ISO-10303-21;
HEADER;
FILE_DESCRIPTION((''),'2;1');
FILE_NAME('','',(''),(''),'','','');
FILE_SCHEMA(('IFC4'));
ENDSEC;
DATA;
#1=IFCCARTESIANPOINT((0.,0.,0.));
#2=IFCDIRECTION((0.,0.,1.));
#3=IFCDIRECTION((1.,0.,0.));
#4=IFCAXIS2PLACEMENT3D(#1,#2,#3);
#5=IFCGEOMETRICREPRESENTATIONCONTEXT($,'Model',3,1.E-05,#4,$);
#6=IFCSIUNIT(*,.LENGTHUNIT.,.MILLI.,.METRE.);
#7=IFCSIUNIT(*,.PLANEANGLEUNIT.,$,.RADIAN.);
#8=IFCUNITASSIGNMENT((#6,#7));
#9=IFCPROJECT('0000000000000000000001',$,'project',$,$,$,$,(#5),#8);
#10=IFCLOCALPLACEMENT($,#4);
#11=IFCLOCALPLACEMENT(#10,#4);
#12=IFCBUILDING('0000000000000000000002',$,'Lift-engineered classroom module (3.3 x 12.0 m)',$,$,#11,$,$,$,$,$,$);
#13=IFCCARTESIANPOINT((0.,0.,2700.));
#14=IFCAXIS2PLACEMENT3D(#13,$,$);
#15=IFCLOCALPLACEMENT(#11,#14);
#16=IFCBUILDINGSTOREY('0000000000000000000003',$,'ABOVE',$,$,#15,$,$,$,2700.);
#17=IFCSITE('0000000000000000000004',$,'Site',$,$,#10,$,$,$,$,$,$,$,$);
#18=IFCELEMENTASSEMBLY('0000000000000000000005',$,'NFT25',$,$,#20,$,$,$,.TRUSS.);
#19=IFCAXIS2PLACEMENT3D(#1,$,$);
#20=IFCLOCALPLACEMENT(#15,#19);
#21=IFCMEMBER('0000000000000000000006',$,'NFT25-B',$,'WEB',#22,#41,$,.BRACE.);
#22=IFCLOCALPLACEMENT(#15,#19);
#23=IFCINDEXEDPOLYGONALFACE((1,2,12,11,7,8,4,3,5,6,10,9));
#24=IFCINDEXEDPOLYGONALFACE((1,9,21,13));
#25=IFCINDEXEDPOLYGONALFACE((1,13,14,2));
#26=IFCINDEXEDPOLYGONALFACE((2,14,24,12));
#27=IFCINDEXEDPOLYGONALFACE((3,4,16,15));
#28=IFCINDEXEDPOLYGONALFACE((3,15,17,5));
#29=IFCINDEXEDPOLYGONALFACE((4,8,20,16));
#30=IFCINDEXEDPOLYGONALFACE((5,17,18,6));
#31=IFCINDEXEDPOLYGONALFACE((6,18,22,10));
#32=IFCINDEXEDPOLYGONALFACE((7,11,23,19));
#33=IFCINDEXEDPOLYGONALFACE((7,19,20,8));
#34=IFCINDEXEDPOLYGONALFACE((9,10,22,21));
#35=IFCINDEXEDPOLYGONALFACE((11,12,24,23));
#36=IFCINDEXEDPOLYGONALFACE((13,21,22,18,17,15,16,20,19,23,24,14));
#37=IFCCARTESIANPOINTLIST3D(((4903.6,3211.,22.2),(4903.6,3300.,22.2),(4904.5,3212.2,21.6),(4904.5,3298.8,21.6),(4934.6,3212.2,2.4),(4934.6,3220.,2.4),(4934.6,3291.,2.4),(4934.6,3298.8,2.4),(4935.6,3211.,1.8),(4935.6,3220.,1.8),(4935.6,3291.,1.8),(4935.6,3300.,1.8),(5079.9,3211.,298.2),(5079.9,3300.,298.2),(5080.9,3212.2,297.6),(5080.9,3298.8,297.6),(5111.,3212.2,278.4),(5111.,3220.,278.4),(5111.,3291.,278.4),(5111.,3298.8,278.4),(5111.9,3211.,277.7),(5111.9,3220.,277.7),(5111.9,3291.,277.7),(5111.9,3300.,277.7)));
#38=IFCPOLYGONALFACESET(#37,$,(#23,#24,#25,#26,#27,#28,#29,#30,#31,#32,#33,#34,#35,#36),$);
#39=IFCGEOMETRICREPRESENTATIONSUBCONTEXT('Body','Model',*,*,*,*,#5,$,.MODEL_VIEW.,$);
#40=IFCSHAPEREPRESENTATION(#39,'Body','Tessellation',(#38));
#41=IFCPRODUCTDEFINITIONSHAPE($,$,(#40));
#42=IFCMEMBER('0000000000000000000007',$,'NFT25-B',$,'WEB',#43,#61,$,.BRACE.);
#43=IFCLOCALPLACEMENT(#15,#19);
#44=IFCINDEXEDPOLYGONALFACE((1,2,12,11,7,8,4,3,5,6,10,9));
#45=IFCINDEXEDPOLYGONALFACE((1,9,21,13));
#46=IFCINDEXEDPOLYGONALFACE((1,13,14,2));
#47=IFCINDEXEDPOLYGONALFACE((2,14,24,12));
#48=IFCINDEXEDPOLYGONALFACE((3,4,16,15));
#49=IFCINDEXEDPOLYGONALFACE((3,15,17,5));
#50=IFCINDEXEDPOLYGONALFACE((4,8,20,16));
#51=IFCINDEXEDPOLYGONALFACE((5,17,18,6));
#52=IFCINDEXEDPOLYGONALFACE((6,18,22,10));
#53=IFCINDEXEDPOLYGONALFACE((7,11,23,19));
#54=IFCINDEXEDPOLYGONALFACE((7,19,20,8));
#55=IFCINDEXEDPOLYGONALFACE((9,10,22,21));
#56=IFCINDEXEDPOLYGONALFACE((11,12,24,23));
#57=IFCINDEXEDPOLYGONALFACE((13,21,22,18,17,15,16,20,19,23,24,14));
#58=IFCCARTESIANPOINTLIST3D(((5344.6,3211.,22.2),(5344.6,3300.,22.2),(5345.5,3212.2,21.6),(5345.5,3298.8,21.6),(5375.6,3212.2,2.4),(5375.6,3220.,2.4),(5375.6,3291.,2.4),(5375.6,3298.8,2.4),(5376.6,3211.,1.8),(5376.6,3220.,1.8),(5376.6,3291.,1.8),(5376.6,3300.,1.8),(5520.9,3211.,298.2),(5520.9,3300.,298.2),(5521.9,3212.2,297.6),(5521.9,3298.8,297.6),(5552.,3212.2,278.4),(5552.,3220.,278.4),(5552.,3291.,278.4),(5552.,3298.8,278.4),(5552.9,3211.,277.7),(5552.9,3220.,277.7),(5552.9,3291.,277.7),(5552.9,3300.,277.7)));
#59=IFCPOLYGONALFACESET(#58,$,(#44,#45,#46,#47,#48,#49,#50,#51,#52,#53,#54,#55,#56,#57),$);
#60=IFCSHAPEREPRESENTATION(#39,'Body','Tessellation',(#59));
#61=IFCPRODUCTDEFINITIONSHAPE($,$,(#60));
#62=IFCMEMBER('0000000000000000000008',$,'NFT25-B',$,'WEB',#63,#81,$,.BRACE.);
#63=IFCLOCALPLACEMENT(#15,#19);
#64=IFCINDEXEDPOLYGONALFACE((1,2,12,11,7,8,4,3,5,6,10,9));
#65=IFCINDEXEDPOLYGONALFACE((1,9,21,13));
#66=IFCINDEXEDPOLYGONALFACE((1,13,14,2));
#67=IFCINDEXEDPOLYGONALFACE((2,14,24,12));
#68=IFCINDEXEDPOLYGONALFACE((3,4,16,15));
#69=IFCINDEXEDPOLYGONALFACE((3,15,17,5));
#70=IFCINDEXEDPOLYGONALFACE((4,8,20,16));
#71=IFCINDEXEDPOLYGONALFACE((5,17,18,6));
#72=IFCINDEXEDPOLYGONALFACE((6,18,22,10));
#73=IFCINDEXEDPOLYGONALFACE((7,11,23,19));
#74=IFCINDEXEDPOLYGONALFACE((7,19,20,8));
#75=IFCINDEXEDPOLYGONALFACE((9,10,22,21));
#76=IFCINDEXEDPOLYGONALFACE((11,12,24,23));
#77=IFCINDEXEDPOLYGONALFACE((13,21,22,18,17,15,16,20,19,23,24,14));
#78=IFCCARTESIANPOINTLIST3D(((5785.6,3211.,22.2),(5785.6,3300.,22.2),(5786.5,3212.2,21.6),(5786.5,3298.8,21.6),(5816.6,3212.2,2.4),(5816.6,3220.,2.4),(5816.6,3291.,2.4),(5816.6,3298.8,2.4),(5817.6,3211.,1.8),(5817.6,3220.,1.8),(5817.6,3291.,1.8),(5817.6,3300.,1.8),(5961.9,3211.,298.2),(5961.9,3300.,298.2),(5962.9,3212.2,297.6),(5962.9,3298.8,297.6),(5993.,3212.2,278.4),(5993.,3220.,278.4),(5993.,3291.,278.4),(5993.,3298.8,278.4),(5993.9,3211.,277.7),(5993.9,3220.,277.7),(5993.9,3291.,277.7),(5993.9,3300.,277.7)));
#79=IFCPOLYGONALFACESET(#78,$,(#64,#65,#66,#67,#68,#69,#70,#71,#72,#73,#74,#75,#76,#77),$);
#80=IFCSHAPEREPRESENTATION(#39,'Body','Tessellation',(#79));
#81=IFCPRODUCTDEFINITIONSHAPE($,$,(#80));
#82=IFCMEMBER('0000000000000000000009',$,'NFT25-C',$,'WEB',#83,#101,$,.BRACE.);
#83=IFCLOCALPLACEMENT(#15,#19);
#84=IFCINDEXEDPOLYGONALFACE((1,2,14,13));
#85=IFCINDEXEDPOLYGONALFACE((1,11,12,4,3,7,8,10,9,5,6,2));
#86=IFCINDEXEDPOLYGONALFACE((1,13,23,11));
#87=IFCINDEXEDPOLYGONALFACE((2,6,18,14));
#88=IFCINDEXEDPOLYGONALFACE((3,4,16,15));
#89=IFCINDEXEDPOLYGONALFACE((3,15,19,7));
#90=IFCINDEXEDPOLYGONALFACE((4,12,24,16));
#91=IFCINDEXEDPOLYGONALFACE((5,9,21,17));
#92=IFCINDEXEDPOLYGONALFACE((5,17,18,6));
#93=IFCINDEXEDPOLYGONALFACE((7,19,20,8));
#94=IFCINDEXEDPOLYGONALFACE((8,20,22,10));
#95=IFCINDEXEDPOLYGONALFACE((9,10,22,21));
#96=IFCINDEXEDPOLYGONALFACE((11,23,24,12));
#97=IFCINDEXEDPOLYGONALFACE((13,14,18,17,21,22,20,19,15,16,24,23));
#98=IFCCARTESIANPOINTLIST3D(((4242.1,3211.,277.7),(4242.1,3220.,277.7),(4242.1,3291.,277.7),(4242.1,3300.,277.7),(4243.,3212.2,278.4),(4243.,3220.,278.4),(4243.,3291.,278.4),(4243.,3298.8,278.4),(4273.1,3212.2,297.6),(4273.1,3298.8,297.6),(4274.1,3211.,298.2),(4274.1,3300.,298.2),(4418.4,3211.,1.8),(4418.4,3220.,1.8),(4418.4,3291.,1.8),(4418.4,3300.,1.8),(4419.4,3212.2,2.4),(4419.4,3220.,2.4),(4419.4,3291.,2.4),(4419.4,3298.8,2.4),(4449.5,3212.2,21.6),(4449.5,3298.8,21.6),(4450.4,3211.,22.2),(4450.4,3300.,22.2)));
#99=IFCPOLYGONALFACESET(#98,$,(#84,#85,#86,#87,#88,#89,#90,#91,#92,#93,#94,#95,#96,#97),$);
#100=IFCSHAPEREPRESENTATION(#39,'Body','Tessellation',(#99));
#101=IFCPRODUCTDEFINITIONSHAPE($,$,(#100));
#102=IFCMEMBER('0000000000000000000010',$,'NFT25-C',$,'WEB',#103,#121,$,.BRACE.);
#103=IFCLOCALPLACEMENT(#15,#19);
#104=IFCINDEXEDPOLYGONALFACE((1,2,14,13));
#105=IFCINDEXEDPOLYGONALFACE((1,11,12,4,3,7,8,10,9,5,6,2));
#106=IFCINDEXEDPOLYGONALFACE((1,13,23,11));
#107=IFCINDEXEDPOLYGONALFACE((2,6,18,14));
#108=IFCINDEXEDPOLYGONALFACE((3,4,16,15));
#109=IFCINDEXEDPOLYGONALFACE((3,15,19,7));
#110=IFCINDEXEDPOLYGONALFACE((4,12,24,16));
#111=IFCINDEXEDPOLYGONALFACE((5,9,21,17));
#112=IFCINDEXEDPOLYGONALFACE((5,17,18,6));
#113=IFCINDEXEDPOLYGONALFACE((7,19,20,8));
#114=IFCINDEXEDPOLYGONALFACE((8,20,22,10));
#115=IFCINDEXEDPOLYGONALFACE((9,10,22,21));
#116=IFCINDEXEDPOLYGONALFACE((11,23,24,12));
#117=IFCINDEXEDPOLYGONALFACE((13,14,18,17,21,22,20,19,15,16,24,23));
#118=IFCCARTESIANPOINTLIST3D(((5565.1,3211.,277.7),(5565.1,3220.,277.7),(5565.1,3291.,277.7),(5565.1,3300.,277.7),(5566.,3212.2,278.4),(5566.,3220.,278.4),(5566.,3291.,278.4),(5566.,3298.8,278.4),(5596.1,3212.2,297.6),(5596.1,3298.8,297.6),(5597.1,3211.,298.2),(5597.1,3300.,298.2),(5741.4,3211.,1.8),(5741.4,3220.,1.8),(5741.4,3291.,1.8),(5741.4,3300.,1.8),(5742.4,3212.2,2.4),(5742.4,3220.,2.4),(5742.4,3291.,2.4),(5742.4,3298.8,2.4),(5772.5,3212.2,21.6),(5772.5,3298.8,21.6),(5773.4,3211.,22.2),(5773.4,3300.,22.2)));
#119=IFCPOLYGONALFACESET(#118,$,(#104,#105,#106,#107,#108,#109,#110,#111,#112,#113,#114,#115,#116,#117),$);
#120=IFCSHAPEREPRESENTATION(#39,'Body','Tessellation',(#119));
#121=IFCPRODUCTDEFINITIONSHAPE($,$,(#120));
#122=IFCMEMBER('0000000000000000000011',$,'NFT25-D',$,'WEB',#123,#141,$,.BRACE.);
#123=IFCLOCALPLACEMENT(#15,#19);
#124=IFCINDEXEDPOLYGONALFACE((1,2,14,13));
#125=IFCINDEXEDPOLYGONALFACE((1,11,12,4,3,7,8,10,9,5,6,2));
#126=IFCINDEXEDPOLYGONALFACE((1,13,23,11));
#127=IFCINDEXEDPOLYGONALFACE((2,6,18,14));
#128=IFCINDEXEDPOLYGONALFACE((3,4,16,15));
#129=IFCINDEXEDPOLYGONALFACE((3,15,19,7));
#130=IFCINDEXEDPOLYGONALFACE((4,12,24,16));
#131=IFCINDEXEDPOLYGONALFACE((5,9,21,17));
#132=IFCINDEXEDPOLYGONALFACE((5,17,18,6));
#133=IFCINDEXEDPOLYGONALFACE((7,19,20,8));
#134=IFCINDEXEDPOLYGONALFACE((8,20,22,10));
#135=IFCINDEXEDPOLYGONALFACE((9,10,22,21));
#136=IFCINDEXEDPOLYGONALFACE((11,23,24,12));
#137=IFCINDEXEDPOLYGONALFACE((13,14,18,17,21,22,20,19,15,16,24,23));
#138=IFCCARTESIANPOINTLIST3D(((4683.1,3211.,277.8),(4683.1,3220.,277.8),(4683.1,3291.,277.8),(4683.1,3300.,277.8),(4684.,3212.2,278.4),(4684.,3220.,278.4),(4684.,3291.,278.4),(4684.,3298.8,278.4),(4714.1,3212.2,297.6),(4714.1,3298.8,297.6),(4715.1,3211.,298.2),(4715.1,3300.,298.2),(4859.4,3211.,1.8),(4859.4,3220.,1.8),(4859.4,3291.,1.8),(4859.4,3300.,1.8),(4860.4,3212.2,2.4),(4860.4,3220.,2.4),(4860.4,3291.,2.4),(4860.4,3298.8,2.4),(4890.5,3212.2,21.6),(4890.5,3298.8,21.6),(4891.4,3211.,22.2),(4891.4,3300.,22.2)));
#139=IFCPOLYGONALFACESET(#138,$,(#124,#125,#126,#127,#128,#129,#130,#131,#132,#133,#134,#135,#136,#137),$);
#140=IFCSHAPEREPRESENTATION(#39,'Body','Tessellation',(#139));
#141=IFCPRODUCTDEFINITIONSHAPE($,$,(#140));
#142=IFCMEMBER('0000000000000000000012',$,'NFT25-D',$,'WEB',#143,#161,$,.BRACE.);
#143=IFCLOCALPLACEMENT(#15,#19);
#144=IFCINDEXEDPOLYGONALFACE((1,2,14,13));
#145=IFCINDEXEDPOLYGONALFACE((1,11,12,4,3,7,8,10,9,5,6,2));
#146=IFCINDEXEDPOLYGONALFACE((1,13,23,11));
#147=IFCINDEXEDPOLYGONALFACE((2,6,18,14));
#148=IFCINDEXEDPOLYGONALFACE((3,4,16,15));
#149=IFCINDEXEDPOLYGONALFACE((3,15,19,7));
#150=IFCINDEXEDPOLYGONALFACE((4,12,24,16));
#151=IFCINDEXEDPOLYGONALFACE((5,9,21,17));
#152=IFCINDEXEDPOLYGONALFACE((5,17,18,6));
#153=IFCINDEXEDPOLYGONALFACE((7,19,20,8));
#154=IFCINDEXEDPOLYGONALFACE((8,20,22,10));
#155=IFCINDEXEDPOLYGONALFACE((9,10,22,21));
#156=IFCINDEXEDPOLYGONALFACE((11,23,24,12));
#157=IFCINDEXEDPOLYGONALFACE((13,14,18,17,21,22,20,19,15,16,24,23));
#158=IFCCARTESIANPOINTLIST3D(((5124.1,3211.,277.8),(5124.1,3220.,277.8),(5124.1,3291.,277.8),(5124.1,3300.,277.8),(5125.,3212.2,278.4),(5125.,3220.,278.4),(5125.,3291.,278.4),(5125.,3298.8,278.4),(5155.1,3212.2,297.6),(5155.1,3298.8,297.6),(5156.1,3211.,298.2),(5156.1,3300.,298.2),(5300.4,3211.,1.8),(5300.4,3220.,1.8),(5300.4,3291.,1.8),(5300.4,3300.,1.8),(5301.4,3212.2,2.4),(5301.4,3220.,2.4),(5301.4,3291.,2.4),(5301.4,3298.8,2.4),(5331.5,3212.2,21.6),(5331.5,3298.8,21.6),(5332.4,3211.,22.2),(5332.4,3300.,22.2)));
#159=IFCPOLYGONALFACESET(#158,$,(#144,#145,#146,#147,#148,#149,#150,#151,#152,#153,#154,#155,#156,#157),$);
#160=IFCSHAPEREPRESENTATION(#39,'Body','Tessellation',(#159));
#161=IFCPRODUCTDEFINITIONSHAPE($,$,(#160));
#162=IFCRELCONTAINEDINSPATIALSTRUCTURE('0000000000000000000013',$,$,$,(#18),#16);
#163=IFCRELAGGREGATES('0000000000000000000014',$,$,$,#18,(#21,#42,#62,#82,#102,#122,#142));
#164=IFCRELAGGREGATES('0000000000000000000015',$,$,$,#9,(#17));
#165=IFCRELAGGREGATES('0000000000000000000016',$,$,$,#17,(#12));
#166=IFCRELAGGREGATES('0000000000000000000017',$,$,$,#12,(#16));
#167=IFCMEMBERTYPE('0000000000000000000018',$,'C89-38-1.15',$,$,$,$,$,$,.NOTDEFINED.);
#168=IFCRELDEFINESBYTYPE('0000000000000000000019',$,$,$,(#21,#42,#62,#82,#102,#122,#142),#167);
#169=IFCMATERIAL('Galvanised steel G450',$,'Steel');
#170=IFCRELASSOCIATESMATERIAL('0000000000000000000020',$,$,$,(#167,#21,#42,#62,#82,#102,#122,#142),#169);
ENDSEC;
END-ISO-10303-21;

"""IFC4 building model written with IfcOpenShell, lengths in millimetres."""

from ifc_helpers import new_model, si_unit, frame, origin, origin_with_axes, origin_2d, place, context, subcontext, project, spatial, c_section, extrude, material, material_profile, profile_set, profile_usage, type_object, element, aggregate, save


model = new_model("IFC4")

# Units and contexts
model_context = context("Model", 3, precision=1e-05, world=origin_with_axes())
body_context = subcontext(model_context, "Body", "Model", "MODEL_VIEW")
ifc_project = project(units=[si_unit("LENGTHUNIT", "METRE", prefix="MILLI"), si_unit("PLANEANGLEUNIT", "RADIAN")], contexts=[model_context])

# Site, building, storey
site_placement = place(None, origin_with_axes())
site = spatial("IfcSite", under=ifc_project, at=site_placement, Name="Site")
building_placement = place(site_placement, origin_with_axes())
building = spatial("IfcBuilding", under=site, at=building_placement, Name="Lift-engineered classroom module (3.3 x 12.0 m)")
storey_placement = place(building_placement, frame((0.0, 0.0, 2700.0)))
storey = spatial("IfcBuildingStorey", under=building, at=storey_placement, Name="ABOVE", Elevation=2700.0)

# Element assembly, members
ifc_material = material(Name="Galvanised steel G450", Category="Steel")
assembly_1_placement = place(storey_placement, frame((0.0, 3255.5, 0.0)))
assembly_1 = element("IfcElementAssembly", 1, at=assembly_1_placement, inside=storey, Name="NFT25", PredefinedType="TRUSS")
ifc_material_profile_1 = material_profile(ifc_material, c_section(Depth=89.0, Width=38.0, WallThickness=1.1, Girth=9.0, at=origin_2d()), Name="C89-38-1.15")
ifc_profile_set_1 = profile_set([ifc_material_profile_1], Name="C89-38-1.15")
ifc_profile_usage_1 = profile_usage(ifc_profile_set_1)
member_type_1 = type_object("IfcMemberType", Name="C89-38-1.15", PredefinedType="NOTDEFINED", material=ifc_profile_set_1)
member_1_placement = place(assembly_1_placement, frame((4919.6, 0.0, 12.0), z_axis=(0.538459, 0.0, 0.842652), x_axis=(0.842652, 0.0, -0.538459)))
member_1 = element("IfcMember", 2, at=member_1_placement, type_object=member_type_1, material=ifc_profile_usage_1, Name="NFT25-B", ObjectType="WEB", PredefinedType="BRACE", context=body_context, shape_type="SweptSolid", body=[
    extrude(c_section(Depth=89.0, Width=38.0, WallThickness=1.1, Girth=9.0, at=origin_2d()), origin(), (0.0, 0.0, 1.0), 327.5),
])
member_2_placement = place(assembly_1_placement, frame((5360.6, 0.0, 12.0), z_axis=(0.538459, 0.0, 0.842652), x_axis=(0.842652, 0.0, -0.538459)))
member_2 = element("IfcMember", 3, at=member_2_placement, type_object=member_type_1, material=ifc_profile_usage_1, Name="NFT25-B", ObjectType="WEB", PredefinedType="BRACE", context=body_context, shape_type="SweptSolid", body=[
    extrude(c_section(Depth=89.0, Width=38.0, WallThickness=1.1, Girth=9.0, at=origin_2d()), origin(), (0.0, 0.0, 1.0), 327.5),
])
member_3_placement = place(assembly_1_placement, frame((5801.6, 0.0, 12.0), z_axis=(0.538459, 0.0, 0.842652), x_axis=(0.842652, 0.0, -0.538459)))
member_3 = element("IfcMember", 4, at=member_3_placement, type_object=member_type_1, material=ifc_profile_usage_1, Name="NFT25-B", ObjectType="WEB", PredefinedType="BRACE", context=body_context, shape_type="SweptSolid", body=[
    extrude(c_section(Depth=89.0, Width=38.0, WallThickness=1.1, Girth=9.0, at=origin_2d()), origin(), (0.0, 0.0, 1.0), 327.5),
])
member_4_placement = place(assembly_1_placement, frame((4434.4, 0.0, 12.0), z_axis=(-0.538459, 0.0, 0.842652), x_axis=(-0.842652, 0.0, -0.538459)))
member_4 = element("IfcMember", 5, at=member_4_placement, type_object=member_type_1, material=ifc_profile_usage_1, Name="NFT25-C", ObjectType="WEB", PredefinedType="BRACE", context=body_context, shape_type="SweptSolid", body=[
    extrude(c_section(Depth=89.0, Width=38.0, WallThickness=1.1, Girth=9.0, at=origin_2d()), origin(), (0.0, 0.0, 1.0), 327.5),
])
member_5_placement = place(assembly_1_placement, frame((5757.4, 0.0, 12.0), z_axis=(-0.538459, 0.0, 0.842652), x_axis=(-0.842652, 0.0, -0.538459)))
member_5 = element("IfcMember", 6, at=member_5_placement, type_object=member_type_1, material=ifc_profile_usage_1, Name="NFT25-C", ObjectType="WEB", PredefinedType="BRACE", context=body_context, shape_type="SweptSolid", body=[
    extrude(c_section(Depth=89.0, Width=38.0, WallThickness=1.1, Girth=9.0, at=origin_2d()), origin(), (0.0, 0.0, 1.0), 327.5),
])
member_6_placement = place(assembly_1_placement, frame((4875.4, 0.0, 12.0), z_axis=(-0.538437, 0.0, 0.842665), x_axis=(-0.842665, 0.0, -0.538437)))
member_6 = element("IfcMember", 7, at=member_6_placement, type_object=member_type_1, material=ifc_profile_usage_1, Name="NFT25-D", ObjectType="WEB", PredefinedType="BRACE", context=body_context, shape_type="SweptSolid", body=[
    extrude(c_section(Depth=89.0, Width=38.0, WallThickness=1.1, Girth=9.0, at=origin_2d()), origin(), (0.0, 0.0, 1.0), 327.5),
])
member_7_placement = place(assembly_1_placement, frame((5316.4, 0.0, 12.0), z_axis=(-0.538437, 0.0, 0.842665), x_axis=(-0.842665, 0.0, -0.538437)))
member_7 = element("IfcMember", 8, at=member_7_placement, type_object=member_type_1, material=ifc_profile_usage_1, Name="NFT25-D", ObjectType="WEB", PredefinedType="BRACE", context=body_context, shape_type="SweptSolid", body=[
    extrude(c_section(Depth=89.0, Width=38.0, WallThickness=1.1, Girth=9.0, at=origin_2d()), origin(), (0.0, 0.0, 1.0), 327.5),
])
aggregate(assembly_1, [member_1, member_2, member_3, member_4, member_5, member_6, member_7])

save(model, "model.ifc")
